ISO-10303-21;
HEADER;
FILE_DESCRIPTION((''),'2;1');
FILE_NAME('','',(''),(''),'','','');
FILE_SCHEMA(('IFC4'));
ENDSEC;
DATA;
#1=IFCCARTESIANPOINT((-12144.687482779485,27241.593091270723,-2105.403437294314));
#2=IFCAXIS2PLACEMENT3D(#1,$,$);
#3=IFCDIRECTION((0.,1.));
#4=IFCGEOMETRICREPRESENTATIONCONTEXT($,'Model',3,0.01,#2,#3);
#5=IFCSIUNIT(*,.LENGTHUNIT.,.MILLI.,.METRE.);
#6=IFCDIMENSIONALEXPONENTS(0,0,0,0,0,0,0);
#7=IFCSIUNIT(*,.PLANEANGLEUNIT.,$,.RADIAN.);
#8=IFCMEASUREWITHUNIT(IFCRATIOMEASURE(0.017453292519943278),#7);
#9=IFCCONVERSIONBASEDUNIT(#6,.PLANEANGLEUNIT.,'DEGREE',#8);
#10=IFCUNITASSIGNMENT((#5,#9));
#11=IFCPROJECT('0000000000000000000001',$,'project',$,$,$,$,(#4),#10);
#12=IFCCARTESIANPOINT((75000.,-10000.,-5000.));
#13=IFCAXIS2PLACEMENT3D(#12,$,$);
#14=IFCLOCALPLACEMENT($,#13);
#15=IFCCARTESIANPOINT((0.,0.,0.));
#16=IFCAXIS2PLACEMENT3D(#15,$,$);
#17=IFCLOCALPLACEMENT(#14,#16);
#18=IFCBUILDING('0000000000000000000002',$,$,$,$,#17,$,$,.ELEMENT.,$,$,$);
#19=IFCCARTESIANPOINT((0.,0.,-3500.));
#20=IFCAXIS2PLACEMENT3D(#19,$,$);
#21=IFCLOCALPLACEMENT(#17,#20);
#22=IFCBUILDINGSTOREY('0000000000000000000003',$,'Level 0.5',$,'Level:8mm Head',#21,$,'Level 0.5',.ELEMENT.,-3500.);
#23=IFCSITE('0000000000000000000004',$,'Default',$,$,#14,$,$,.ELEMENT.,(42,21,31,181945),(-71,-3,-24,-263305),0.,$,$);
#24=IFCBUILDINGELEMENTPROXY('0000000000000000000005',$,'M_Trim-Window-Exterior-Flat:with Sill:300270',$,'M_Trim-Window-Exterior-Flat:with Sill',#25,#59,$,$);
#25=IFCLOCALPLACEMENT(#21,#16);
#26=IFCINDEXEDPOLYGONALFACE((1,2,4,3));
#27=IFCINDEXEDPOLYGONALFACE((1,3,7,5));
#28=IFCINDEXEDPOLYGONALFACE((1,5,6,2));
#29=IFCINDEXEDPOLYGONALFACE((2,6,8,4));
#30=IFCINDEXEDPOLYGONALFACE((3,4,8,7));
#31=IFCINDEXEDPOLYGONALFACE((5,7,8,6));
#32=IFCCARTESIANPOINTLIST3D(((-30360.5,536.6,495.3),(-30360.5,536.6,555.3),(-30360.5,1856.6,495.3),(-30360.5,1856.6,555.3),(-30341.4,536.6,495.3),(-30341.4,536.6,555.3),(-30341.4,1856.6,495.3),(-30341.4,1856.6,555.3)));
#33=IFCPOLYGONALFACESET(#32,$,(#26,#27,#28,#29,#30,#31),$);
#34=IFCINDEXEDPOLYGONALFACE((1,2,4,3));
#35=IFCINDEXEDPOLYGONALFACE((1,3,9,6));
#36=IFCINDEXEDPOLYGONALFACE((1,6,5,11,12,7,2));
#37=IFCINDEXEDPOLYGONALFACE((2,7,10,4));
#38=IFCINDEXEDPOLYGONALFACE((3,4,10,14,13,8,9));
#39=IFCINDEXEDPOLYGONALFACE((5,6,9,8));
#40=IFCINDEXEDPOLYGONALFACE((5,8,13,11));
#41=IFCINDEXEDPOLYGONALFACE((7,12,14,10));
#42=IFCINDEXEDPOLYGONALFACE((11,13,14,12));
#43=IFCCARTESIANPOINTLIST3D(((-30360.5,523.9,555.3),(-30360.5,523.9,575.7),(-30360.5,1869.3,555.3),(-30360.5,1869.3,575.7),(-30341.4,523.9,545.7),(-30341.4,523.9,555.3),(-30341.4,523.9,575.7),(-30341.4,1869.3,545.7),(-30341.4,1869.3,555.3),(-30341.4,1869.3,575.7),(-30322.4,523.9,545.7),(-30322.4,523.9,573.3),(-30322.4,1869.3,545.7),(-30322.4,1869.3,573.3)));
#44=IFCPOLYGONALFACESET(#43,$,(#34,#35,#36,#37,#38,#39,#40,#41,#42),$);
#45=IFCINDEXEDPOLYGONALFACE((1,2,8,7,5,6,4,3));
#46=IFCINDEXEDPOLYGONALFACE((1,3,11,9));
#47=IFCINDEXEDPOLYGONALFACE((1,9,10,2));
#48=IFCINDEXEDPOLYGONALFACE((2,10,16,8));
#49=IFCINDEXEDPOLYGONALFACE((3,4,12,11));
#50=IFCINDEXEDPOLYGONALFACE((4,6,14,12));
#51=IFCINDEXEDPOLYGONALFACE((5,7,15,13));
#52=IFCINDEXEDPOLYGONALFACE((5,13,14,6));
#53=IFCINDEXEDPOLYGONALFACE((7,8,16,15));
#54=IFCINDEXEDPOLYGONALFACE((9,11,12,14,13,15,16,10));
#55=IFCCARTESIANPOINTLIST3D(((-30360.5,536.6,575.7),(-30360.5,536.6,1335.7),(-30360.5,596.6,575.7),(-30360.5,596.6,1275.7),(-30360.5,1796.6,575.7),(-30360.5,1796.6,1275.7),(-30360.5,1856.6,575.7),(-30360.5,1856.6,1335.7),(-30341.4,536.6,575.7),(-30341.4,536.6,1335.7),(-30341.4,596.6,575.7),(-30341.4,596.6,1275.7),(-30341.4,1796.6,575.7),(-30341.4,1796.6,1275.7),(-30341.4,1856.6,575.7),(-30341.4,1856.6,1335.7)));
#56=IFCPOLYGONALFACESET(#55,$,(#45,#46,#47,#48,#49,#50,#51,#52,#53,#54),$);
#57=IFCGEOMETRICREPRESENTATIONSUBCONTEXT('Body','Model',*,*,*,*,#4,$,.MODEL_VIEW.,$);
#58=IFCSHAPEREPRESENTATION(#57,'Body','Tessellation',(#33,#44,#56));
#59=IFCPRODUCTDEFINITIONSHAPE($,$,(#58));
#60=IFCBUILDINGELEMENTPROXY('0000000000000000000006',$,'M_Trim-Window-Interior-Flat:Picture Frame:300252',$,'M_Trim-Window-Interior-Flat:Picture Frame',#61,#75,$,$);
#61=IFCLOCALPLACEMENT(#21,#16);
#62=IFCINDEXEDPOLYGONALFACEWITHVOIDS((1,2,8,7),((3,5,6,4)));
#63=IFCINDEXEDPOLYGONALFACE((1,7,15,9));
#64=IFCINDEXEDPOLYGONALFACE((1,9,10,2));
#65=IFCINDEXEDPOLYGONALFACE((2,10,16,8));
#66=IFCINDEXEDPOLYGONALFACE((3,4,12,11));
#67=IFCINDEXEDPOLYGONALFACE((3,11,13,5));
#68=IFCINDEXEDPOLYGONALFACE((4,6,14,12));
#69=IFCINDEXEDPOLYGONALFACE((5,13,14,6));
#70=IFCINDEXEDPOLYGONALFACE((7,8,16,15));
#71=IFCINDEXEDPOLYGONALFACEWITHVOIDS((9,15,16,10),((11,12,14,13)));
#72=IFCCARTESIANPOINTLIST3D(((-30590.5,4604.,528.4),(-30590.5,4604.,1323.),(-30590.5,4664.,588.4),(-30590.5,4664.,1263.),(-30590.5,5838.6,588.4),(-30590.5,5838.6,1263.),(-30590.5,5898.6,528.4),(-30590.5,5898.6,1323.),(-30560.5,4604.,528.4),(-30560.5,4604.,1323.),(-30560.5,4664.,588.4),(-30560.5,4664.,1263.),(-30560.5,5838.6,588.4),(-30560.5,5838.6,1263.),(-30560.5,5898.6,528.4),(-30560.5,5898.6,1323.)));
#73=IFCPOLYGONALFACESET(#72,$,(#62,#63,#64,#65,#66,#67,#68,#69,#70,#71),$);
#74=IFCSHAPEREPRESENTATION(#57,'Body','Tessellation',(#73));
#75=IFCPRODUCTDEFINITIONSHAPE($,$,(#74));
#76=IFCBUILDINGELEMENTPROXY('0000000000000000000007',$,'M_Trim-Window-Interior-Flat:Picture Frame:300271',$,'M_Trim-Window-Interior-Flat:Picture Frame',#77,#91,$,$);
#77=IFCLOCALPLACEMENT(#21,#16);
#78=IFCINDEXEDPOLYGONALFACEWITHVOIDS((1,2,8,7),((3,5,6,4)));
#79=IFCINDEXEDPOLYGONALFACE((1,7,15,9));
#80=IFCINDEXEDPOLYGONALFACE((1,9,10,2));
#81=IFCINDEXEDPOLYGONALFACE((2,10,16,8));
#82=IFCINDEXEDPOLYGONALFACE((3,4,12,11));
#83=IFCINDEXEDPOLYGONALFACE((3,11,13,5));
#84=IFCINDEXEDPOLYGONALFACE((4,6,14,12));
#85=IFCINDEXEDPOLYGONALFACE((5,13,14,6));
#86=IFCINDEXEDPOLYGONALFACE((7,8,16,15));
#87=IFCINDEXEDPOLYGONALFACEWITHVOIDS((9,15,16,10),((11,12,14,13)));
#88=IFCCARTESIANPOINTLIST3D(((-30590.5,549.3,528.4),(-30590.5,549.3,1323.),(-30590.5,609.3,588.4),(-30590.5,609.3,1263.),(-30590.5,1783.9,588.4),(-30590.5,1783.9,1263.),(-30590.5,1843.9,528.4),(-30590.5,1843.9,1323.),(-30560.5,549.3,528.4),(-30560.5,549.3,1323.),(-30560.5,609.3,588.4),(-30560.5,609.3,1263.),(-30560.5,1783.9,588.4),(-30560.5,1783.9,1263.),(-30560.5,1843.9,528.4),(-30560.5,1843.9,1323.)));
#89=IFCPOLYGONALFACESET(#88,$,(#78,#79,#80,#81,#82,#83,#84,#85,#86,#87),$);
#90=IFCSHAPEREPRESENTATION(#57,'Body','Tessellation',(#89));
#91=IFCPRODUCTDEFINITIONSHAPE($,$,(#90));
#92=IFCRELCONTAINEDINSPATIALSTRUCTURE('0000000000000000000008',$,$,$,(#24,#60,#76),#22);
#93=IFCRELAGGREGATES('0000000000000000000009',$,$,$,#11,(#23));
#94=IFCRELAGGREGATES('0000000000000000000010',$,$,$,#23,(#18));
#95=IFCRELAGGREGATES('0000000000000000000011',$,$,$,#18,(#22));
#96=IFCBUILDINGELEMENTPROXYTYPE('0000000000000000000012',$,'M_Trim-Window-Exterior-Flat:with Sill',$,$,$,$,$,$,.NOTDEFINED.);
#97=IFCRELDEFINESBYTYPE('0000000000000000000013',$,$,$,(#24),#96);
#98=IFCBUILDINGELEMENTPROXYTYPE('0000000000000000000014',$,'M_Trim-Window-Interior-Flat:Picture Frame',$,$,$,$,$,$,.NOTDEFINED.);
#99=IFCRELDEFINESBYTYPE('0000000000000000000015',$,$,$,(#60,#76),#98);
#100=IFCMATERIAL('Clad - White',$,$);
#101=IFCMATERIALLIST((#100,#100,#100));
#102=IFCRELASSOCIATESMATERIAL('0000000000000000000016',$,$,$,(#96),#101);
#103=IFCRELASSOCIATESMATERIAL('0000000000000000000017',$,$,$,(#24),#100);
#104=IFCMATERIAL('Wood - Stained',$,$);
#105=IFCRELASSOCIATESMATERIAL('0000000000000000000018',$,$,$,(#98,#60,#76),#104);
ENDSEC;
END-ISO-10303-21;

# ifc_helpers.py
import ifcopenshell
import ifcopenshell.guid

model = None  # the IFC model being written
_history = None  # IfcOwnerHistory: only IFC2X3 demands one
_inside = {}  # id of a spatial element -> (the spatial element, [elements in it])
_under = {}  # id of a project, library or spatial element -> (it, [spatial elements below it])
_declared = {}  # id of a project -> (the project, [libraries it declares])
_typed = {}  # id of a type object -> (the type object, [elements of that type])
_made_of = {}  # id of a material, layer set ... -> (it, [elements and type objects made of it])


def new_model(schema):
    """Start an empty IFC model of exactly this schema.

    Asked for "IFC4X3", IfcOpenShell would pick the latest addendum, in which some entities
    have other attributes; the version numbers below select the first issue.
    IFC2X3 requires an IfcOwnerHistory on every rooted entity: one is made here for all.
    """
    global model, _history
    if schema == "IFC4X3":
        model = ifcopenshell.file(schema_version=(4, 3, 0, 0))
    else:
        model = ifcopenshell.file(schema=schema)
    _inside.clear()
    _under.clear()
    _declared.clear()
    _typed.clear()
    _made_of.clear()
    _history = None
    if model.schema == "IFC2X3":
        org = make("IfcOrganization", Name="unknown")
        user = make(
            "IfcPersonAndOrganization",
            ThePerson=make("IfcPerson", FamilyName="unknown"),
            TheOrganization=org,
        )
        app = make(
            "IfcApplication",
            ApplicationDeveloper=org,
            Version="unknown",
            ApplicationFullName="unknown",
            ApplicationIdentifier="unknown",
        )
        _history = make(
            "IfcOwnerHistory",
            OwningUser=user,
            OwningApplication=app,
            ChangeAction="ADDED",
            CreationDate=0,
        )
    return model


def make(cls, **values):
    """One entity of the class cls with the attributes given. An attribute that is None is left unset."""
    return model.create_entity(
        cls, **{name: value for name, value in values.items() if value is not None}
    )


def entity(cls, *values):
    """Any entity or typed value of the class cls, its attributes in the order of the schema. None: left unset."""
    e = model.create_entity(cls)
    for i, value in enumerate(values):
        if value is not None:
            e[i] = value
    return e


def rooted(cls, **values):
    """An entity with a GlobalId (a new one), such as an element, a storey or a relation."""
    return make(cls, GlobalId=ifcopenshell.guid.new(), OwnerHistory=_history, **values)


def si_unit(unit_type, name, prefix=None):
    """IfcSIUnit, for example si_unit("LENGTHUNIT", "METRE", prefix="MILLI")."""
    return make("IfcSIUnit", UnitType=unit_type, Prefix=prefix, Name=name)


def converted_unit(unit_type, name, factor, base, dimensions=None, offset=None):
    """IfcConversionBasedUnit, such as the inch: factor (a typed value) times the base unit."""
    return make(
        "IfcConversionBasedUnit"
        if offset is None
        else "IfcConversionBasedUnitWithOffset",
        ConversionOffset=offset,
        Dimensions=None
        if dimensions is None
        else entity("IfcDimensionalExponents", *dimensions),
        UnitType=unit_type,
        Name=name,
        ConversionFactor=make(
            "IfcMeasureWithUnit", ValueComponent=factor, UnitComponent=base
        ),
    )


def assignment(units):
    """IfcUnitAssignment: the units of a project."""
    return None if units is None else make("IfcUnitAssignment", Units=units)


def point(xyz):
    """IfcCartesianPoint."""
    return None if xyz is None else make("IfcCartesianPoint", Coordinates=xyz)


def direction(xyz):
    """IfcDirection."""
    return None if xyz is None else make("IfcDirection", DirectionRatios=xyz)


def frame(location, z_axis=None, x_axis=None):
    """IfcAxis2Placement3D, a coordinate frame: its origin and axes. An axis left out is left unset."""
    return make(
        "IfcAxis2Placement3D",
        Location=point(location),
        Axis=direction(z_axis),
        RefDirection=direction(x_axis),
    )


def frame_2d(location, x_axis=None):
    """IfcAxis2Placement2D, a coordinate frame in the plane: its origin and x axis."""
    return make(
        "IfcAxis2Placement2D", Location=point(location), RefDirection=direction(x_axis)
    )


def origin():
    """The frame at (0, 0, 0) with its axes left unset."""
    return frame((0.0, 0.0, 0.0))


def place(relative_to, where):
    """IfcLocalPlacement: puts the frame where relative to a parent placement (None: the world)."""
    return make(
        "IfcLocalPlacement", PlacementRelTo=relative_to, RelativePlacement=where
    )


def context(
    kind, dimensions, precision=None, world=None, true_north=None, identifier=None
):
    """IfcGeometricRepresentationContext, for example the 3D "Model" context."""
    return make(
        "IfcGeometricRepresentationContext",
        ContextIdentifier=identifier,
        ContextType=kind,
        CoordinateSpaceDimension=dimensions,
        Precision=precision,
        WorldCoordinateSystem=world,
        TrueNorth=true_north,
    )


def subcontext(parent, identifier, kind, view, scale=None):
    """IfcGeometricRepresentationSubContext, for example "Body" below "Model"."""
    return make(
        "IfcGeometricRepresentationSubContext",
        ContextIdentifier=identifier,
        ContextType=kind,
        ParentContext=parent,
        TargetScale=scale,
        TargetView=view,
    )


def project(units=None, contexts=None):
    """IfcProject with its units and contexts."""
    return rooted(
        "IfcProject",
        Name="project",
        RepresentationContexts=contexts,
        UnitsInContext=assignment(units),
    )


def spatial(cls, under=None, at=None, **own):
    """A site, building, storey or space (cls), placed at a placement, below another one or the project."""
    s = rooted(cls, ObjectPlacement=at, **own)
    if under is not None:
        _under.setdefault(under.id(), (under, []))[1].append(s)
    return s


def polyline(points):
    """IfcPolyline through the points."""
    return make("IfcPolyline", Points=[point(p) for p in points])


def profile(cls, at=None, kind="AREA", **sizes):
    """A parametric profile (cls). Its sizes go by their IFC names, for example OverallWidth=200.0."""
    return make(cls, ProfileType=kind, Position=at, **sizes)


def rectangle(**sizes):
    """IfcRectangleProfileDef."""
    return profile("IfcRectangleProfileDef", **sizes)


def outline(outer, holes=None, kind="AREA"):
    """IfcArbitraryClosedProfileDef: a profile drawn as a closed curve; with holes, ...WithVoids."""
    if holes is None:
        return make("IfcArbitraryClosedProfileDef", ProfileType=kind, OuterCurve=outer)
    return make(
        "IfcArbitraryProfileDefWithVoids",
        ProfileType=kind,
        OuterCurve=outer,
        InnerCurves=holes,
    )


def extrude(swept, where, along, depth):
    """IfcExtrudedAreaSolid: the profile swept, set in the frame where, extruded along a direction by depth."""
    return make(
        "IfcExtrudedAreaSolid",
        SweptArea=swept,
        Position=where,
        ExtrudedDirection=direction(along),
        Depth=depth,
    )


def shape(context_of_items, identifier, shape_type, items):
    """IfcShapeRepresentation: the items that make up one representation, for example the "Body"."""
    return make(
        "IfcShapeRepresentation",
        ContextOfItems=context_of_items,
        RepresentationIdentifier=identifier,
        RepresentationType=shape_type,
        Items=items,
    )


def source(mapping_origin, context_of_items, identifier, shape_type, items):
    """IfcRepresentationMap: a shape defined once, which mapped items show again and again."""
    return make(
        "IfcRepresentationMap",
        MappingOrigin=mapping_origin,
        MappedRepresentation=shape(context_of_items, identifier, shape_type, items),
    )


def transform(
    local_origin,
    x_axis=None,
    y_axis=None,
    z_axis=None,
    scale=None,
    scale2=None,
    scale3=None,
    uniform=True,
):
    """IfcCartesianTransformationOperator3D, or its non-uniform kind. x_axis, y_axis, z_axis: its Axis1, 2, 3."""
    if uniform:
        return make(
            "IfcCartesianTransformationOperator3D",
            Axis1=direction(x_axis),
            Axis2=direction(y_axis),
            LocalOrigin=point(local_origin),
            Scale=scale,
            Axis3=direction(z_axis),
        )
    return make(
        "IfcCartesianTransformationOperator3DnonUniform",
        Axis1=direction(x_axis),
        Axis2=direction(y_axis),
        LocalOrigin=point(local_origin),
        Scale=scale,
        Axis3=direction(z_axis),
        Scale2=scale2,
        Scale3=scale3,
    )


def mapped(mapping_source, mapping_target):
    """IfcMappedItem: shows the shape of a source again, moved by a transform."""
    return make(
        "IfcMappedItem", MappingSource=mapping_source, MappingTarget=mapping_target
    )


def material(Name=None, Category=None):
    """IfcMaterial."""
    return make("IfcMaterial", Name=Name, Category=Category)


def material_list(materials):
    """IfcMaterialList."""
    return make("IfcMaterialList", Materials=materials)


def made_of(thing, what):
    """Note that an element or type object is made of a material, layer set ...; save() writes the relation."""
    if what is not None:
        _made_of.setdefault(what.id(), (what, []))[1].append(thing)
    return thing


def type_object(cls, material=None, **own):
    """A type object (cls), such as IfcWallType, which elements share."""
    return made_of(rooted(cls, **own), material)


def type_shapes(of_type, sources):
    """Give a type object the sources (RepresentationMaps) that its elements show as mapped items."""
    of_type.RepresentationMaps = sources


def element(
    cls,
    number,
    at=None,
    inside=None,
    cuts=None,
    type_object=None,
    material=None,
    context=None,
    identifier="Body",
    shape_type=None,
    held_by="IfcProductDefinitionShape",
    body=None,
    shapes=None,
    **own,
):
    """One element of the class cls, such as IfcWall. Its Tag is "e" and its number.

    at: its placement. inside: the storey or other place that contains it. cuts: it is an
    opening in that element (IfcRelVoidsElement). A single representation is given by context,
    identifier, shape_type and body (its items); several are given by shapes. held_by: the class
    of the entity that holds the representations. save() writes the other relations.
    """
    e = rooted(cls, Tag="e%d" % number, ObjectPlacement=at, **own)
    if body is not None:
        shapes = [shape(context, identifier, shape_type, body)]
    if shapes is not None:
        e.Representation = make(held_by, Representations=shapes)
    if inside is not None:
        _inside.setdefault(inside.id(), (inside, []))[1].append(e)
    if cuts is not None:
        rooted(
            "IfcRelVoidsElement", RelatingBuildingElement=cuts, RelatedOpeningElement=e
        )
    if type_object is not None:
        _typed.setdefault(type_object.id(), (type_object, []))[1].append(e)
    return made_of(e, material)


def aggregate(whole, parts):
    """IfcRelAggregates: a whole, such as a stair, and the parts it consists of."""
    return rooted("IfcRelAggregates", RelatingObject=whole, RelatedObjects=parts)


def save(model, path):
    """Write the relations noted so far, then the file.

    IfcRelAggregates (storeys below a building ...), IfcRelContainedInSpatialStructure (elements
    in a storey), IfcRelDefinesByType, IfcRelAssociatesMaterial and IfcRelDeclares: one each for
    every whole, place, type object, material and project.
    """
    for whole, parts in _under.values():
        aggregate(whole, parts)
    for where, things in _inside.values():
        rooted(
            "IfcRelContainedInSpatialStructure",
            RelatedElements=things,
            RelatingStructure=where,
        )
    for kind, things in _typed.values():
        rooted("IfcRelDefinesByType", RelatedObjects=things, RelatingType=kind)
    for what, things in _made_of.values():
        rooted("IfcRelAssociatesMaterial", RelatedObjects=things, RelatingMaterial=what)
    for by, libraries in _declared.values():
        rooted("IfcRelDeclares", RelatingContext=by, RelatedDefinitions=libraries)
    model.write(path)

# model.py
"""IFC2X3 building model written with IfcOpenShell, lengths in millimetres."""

from ifc_helpers import new_model, entity, si_unit, converted_unit, direction, frame, frame_2d, origin, place, context, subcontext, project, spatial, polyline, rectangle, outline, extrude, source, transform, mapped, material, material_list, type_object, type_shapes, element, save


model = new_model("IFC2X3")

# Units and contexts
model_context = context("Model", 3, precision=0.01, world=frame((-12144.687482779485, 27241.593091270723, -2105.403437294314)), true_north=direction((0.0, 1.0)))
body_context = subcontext(model_context, "Body", "Model", "MODEL_VIEW")
ifc_project = project(units=[si_unit("LENGTHUNIT", "METRE", prefix="MILLI"), converted_unit("PLANEANGLEUNIT", "DEGREE", entity("IfcRatioMeasure", 0.017453292519943278), si_unit("PLANEANGLEUNIT", "RADIAN"), dimensions=[0, 0, 0, 0, 0, 0, 0])], contexts=[model_context])

# Site, building, storey
site_placement = place(None, frame((75000.0, -10000.0, -5000.0)))
site = spatial("IfcSite", under=ifc_project, at=site_placement, Name="Default", CompositionType="ELEMENT", RefLatitude=(42, 21, 31, 181945), RefLongitude=(-71, -3, -24, -263305), RefElevation=0.0)
building_placement = place(site_placement, origin())
building = spatial("IfcBuilding", under=site, at=building_placement, CompositionType="ELEMENT")
storey_placement = place(building_placement, frame((0.0, 0.0, -3500.0)))
storey = spatial("IfcBuildingStorey", under=building, at=storey_placement, Name="Level 0.5", ObjectType="Level:8mm Head", LongName="Level 0.5", CompositionType="ELEMENT", Elevation=-3500.0)

# Building element proxies
ifc_material_1 = material(Name="Clad - White")
ifc_material_2 = material(Name="Wood - Stained")
ifc_material_list_1 = material_list([ifc_material_1, ifc_material_1, ifc_material_1])
building_element_proxy_type_1 = type_object("IfcBuildingElementProxyType", Name="M_Trim-Window-Exterior-Flat:with Sill", PredefinedType="NOTDEFINED", material=ifc_material_list_1)
shared_shape_1 = source(origin(), body_context, "Body", "SweptSolid", [
    extrude(rectangle(XDim=1320.0, YDim=60.0, at=frame_2d((0.0, 0.0), x_axis=(1.0, 0.0))), frame((0.0, -750.4, 0.0), z_axis=(0.0, 0.0, 1.0), x_axis=(-1.0, 0.0, 0.0)), (0.0, 0.0, 1.0), 19.0),
    extrude(outline(polyline([(-19.0, -15.2), (0.0, -15.2), (0.0, -5.7), (19.0, -5.7), (19.0, 14.8), (0.0, 14.8), (-19.0, 12.3), (-19.0, -15.2)])), frame((-672.7, -714.8, 19.0), z_axis=(1.0, 0.0, 0.0), x_axis=(0.0, 0.0, -1.0)), (0.0, 0.0, 1.0), 1345.4),
    extrude(outline(polyline([(-395.0, -660.0), (365.0, -660.0), (365.0, -600.0), (-335.0, -600.0), (-335.0, 600.0), (365.0, 600.0), (365.0, 660.0), (-395.0, 660.0), (-395.0, -660.0)])), frame((0.0, -335.0, 0.0), z_axis=(0.0, 0.0, 1.0), x_axis=(0.0, -1.0, 0.0)), (0.0, 0.0, 1.0), 19.0),
])
type_shapes(building_element_proxy_type_1, [shared_shape_1])
for number, where, z_axis, x_axis, name in (
    (1, (-30360.5, 1196.6, 1275.7), (1.0, 0.0, 0.0), (0.0, 1.0, 0.0), "M_Trim-Window-Exterior-Flat:with Sill:300270"),
):
    element("IfcBuildingElementProxy", number, at=place(storey_placement, frame(where, z_axis=z_axis, x_axis=x_axis)), inside=storey, type_object=building_element_proxy_type_1, material=ifc_material_1, Name=name, ObjectType="M_Trim-Window-Exterior-Flat:with Sill", context=body_context, shape_type="MappedRepresentation", body=[
        mapped(shared_shape_1, transform((0.0, 0.0, 0.0), scale=1.0)),
    ])
building_element_proxy_type_2 = type_object("IfcBuildingElementProxyType", Name="M_Trim-Window-Interior-Flat:Picture Frame", PredefinedType="NOTDEFINED", material=ifc_material_2)
shared_shape_2 = source(origin(), body_context, "Body", "SweptSolid", [
    extrude(outline(polyline([(-647.3, -397.3), (647.3, -397.3), (647.3, 397.3), (-647.3, 397.3), (-647.3, -397.3)]), holes=[polyline([(-587.3, -337.3), (-587.3, 337.3), (587.3, 337.3), (587.3, -337.3), (-587.3, -337.3)])]), frame((0.0, -350.0, 0.0), z_axis=(0.0, 0.0, 1.0), x_axis=(-1.0, 0.0, 0.0)), (0.0, 0.0, 1.0), 30.0),
])
type_shapes(building_element_proxy_type_2, [shared_shape_2])
for number, where, z_axis, x_axis, name in (
    (2, (-30560.5, 5251.3, 1275.7), (-1.0, 0.0, 0.0), (0.0, -1.0, 0.0), "M_Trim-Window-Interior-Flat:Picture Frame:300252"),
    (3, (-30560.5, 1196.6, 1275.7), (-1.0, 0.0, 0.0), (0.0, -1.0, 0.0), "M_Trim-Window-Interior-Flat:Picture Frame:300271"),
):
    element("IfcBuildingElementProxy", number, at=place(storey_placement, frame(where, z_axis=z_axis, x_axis=x_axis)), inside=storey, type_object=building_element_proxy_type_2, material=ifc_material_2, Name=name, ObjectType="M_Trim-Window-Interior-Flat:Picture Frame", context=body_context, shape_type="MappedRepresentation", body=[
        mapped(shared_shape_2, transform((0.0, 0.0, 0.0), scale=1.0)),
    ])

save(model, "model.ifc")
